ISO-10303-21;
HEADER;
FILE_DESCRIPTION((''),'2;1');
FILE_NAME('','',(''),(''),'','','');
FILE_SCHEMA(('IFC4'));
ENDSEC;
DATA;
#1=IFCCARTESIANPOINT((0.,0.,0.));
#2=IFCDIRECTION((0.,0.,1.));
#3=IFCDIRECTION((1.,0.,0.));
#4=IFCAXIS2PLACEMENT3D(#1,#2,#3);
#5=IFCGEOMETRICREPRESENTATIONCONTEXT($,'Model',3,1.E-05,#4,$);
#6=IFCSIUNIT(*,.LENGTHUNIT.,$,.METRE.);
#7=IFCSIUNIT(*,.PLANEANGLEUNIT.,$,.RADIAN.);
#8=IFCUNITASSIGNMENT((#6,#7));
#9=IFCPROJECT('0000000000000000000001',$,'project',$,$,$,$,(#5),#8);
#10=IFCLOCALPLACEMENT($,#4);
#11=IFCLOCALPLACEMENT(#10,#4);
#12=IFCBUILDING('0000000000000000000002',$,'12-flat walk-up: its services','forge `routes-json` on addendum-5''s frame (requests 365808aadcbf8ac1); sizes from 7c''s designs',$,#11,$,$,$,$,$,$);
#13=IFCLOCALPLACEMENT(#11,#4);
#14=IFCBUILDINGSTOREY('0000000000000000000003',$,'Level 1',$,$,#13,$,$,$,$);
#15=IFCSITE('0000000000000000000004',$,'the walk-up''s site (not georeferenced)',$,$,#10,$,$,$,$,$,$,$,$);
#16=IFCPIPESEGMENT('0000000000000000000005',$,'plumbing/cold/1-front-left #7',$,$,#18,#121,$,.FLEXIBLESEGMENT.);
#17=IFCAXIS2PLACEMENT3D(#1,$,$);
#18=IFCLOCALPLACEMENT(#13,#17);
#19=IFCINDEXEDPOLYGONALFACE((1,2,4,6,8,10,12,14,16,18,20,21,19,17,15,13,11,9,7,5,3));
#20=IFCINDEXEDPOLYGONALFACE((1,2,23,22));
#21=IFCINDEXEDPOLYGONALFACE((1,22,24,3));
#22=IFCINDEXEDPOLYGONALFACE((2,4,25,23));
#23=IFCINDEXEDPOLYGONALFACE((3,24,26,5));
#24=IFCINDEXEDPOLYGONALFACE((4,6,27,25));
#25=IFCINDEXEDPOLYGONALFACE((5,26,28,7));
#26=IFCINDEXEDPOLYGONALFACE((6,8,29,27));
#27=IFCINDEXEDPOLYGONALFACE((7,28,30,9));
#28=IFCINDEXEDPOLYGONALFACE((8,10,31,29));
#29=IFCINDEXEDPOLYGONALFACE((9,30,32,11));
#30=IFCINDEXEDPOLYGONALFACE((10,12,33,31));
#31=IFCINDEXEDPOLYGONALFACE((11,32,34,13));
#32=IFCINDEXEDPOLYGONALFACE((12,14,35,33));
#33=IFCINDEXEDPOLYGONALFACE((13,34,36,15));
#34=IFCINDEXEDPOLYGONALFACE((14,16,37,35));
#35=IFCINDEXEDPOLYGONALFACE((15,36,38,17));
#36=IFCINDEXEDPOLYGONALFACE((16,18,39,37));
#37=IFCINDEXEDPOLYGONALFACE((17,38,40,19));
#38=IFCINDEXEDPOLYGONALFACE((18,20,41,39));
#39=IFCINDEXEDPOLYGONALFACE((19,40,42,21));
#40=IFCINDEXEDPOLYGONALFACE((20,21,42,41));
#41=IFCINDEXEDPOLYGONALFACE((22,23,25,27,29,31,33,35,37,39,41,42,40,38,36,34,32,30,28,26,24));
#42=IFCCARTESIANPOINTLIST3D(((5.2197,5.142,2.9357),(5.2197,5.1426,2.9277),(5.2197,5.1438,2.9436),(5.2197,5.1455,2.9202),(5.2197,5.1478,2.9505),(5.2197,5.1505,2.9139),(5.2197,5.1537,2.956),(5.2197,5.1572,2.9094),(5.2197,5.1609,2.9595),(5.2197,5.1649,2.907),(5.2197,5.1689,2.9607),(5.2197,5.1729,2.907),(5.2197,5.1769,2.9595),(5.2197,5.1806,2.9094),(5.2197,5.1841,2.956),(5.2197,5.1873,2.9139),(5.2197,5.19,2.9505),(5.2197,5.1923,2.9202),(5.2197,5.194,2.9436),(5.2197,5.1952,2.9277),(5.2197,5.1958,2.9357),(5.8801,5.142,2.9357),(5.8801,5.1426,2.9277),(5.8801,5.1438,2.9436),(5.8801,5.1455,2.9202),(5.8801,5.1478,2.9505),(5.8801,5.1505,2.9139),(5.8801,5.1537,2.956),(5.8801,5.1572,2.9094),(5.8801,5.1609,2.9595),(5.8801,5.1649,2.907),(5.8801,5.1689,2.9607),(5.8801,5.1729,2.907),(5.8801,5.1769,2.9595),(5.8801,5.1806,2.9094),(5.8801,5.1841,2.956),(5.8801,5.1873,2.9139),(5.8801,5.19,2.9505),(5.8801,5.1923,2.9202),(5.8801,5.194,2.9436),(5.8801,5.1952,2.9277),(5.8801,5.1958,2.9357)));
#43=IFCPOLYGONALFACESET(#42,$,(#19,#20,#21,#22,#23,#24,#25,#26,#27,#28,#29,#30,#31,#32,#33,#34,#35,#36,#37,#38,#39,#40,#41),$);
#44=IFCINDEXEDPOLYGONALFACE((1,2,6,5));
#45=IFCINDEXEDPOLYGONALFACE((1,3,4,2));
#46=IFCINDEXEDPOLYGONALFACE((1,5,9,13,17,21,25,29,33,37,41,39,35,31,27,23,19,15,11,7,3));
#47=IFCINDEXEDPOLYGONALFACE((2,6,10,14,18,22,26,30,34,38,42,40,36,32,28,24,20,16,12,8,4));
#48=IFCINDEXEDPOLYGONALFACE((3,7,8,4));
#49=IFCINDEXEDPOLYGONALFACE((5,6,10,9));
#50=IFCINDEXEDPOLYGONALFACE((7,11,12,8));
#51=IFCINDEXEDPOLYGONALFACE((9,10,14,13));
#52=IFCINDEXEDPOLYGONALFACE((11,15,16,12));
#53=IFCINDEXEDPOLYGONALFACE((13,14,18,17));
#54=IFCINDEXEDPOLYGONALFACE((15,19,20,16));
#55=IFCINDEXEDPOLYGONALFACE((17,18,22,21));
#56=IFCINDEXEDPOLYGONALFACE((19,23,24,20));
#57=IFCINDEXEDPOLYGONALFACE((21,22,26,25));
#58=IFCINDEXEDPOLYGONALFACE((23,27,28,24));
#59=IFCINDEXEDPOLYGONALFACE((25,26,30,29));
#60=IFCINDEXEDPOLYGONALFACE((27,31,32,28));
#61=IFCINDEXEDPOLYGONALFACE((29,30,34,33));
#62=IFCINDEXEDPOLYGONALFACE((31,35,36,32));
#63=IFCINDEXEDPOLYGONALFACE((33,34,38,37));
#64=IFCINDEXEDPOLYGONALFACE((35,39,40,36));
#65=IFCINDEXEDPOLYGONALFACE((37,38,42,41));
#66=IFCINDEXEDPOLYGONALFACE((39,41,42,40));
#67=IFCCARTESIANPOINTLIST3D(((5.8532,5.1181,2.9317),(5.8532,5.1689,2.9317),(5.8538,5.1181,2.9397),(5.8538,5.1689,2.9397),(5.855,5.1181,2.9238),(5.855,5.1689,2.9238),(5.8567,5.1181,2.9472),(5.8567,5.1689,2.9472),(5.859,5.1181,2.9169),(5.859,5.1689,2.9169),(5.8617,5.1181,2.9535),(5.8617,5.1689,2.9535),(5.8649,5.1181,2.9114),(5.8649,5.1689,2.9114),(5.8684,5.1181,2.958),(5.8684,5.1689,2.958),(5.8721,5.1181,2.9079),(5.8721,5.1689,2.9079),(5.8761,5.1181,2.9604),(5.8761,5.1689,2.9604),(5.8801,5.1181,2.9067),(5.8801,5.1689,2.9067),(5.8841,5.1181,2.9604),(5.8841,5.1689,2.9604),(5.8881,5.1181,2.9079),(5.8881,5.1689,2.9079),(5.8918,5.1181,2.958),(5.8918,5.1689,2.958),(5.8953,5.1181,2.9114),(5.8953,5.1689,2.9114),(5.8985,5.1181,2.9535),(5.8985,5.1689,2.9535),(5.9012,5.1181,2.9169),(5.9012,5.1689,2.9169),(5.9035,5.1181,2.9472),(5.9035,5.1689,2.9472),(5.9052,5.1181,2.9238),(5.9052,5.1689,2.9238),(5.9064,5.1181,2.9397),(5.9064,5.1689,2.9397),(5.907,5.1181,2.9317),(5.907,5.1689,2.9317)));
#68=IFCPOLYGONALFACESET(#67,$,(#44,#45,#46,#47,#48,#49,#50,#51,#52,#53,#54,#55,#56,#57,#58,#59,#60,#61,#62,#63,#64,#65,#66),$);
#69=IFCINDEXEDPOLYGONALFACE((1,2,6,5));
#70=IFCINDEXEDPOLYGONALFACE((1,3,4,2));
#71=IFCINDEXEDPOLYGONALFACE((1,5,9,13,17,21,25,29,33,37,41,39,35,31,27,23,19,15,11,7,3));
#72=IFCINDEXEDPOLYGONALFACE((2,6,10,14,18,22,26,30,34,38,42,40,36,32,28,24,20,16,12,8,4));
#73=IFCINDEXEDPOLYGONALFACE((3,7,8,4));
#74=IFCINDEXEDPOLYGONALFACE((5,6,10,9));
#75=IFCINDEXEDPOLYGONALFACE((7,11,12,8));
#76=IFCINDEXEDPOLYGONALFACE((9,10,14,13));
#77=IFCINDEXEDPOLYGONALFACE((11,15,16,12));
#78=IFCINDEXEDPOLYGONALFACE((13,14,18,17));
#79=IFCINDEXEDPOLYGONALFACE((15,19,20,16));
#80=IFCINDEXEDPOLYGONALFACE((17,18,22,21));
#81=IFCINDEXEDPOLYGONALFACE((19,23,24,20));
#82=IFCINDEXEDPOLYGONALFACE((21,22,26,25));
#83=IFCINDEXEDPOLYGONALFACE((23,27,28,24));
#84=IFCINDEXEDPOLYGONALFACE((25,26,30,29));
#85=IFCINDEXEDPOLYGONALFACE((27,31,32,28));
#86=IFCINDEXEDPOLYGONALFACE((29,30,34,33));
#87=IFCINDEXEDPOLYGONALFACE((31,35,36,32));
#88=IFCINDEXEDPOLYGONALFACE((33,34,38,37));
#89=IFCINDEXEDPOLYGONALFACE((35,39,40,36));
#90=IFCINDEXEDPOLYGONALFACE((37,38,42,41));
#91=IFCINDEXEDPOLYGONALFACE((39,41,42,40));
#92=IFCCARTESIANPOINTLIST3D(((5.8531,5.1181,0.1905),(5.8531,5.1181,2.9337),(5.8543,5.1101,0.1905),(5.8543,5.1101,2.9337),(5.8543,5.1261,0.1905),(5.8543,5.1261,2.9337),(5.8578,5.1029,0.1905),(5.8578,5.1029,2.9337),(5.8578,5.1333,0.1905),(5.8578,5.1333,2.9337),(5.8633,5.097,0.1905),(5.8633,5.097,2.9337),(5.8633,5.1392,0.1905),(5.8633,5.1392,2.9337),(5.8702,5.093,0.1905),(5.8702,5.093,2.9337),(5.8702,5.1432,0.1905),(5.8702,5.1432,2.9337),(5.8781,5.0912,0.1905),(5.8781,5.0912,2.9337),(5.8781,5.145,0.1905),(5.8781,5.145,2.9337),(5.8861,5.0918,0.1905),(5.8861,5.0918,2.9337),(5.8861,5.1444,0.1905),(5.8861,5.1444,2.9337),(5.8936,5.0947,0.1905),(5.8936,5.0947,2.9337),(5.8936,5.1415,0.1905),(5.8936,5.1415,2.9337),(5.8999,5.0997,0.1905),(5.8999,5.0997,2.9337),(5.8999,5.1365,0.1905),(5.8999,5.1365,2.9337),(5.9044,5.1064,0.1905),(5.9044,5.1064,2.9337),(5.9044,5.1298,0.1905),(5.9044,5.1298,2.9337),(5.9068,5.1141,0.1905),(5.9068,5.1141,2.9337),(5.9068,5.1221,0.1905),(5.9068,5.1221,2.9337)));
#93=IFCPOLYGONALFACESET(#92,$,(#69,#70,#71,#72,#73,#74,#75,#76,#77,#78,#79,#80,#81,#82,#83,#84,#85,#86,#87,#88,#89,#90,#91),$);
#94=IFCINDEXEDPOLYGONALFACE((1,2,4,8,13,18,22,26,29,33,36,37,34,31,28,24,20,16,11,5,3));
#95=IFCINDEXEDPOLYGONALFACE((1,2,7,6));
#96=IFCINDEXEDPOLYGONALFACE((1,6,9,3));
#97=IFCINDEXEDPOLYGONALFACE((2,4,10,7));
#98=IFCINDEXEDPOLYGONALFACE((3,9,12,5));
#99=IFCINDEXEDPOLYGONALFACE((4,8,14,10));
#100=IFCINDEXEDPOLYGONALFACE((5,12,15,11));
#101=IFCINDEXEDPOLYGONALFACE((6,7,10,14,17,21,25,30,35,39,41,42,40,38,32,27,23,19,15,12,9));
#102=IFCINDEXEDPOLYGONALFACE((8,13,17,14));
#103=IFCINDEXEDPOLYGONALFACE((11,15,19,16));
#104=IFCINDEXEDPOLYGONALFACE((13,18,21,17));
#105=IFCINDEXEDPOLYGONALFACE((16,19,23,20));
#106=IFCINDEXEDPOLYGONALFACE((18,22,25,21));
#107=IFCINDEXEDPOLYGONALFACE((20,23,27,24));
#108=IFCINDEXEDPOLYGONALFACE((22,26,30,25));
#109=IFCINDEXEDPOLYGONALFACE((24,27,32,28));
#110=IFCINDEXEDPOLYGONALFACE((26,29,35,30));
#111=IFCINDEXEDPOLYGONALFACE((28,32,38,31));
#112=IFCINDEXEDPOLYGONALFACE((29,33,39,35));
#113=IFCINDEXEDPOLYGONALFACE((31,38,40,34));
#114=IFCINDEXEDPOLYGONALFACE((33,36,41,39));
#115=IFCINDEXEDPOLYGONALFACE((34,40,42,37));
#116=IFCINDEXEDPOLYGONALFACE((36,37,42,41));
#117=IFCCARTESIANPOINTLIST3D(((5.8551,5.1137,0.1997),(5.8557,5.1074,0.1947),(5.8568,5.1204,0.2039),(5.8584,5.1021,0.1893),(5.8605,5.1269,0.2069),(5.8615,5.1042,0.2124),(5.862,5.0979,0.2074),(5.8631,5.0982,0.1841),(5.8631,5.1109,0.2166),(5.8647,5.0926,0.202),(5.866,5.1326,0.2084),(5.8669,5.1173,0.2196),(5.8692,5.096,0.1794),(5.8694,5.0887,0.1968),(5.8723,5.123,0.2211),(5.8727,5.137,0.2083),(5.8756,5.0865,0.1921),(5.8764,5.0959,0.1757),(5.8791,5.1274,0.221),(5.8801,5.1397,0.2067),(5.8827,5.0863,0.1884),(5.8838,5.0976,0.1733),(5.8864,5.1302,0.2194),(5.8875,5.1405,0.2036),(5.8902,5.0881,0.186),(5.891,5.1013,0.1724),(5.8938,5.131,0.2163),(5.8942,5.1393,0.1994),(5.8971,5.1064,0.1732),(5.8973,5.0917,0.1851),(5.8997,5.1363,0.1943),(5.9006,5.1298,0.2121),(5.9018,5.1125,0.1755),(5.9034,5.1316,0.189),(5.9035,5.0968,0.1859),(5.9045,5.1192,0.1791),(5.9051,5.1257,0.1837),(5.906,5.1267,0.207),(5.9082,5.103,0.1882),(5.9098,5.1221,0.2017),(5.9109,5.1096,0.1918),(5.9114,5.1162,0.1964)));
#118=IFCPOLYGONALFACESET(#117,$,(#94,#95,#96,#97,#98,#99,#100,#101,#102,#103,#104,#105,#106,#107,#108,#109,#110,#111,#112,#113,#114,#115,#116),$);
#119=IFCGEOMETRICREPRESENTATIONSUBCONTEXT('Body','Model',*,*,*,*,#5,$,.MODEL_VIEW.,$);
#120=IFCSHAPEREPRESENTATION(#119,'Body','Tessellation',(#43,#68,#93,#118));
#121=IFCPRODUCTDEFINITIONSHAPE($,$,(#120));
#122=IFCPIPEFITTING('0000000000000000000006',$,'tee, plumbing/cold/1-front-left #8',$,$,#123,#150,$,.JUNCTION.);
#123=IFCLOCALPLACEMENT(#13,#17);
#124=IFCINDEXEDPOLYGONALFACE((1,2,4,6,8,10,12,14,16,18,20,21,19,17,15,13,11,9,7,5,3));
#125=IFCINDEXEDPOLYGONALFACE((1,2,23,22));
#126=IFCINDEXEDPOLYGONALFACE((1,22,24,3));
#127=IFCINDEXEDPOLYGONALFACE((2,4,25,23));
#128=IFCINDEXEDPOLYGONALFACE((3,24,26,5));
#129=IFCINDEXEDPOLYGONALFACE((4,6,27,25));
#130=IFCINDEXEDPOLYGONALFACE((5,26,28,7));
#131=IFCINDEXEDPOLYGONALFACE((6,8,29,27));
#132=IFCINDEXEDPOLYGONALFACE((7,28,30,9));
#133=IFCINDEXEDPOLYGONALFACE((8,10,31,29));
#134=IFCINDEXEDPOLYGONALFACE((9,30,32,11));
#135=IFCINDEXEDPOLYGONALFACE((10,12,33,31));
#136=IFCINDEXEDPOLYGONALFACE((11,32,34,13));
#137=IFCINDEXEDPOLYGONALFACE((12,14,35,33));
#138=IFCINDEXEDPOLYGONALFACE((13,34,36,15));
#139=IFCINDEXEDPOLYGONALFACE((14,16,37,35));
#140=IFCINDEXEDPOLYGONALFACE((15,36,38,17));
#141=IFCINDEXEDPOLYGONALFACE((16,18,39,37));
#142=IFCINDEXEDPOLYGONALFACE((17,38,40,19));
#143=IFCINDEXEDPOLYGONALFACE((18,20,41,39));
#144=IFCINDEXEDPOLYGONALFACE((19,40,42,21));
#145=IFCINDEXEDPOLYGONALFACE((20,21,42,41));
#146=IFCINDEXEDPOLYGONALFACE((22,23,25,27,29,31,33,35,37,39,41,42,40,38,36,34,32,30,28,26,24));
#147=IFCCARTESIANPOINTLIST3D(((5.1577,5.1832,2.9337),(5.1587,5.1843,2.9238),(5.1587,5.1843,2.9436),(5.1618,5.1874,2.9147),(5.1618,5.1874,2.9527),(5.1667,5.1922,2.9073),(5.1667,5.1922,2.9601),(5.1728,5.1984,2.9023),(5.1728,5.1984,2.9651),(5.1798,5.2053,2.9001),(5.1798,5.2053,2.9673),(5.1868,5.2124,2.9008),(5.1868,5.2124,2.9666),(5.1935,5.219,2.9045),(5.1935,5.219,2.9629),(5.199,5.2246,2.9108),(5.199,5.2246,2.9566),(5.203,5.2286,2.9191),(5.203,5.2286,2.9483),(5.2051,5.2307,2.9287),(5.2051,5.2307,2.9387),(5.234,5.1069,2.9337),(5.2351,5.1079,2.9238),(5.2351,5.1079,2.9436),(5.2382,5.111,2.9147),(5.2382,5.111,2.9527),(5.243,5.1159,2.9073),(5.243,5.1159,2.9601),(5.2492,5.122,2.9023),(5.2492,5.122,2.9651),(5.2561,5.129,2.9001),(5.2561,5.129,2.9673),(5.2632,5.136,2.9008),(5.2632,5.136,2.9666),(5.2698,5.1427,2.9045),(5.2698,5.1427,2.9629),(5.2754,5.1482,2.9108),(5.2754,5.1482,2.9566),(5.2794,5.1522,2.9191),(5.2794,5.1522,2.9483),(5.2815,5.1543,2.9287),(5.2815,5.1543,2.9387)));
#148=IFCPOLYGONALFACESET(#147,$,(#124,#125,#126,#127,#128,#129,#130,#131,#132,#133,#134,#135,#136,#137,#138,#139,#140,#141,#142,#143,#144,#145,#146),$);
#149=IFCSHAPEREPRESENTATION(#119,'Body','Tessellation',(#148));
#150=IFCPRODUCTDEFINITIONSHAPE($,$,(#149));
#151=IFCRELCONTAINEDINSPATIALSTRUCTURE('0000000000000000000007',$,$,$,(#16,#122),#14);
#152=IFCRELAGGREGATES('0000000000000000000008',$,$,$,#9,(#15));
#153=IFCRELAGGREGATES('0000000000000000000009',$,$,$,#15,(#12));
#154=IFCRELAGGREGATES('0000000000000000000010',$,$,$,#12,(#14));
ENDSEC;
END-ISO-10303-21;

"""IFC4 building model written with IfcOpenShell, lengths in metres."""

from ifc_helpers import new_model, entity, si_unit, frame, origin_with_axes, place, context, subcontext, project, spatial, element, save


model = new_model("IFC4")

# Units and contexts
model_context = context("Model", 3, precision=1e-05, world=origin_with_axes())
body_context = subcontext(model_context, "Body", "Model", "MODEL_VIEW")
ifc_project = project(units=[si_unit("LENGTHUNIT", "METRE"), si_unit("PLANEANGLEUNIT", "RADIAN")], contexts=[model_context])

# Site, building, storey
site_placement = place(None, origin_with_axes())
site = spatial("IfcSite", under=ifc_project, at=site_placement, Name="the walk-up's site (not georeferenced)")
building_placement = place(site_placement, origin_with_axes())
building = spatial("IfcBuilding", under=site, at=building_placement, Name="12-flat walk-up: its services", Description="forge `routes-json` on addendum-5's frame (requests 365808aadcbf8ac1); sizes from 7c's designs")
storey_placement = place(building_placement, origin_with_axes())
storey = spatial("IfcBuildingStorey", under=building, at=storey_placement, Name="Level 1")

# Pipe segment
pipe_segment_1_placement = place(storey_placement, frame((5.2197, 5.1689, 2.9337), z_axis=(0.0, 0.0, 1.0), x_axis=(1.0, 0.0, 0.0)))
element("IfcPipeSegment", 1, at=pipe_segment_1_placement, inside=storey, Name="plumbing/cold/1-front-left #7", PredefinedType="FLEXIBLESEGMENT", context=body_context, shape_type="AdvancedSweptSolid", body=[
    entity("IfcSweptDiskSolid", entity("IfcPolyline", [entity("IfcCartesianPoint", [0.0, 0.0, 0.0]), entity("IfcCartesianPoint", [0.6604, 0.0, 0.0])]), 0.027),
    entity("IfcSweptDiskSolid", entity("IfcPolyline", [entity("IfcCartesianPoint", [0.6604, 0.0, 0.0]), entity("IfcCartesianPoint", [0.6604, -0.0508, 0.0])]), 0.027),
    entity("IfcSweptDiskSolid", entity("IfcPolyline", [entity("IfcCartesianPoint", [0.6604, -0.0508, 0.0]), entity("IfcCartesianPoint", [0.6604, -0.0508, -2.7432])]), 0.027),
    entity("IfcSweptDiskSolid", entity("IfcPolyline", [entity("IfcCartesianPoint", [0.6604, -0.0508, -2.7432]), entity("IfcCartesianPoint", [0.6668, -0.0603, -2.7305])]), 0.027),
])

# Pipe fitting
pipe_fitting_1_placement = place(storey_placement, frame((5.1815, 5.2071, 2.9337), z_axis=(0.0, 0.0, 1.0), x_axis=(1.0, 0.0, 0.0)))
element("IfcPipeFitting", 2, at=pipe_fitting_1_placement, inside=storey, Name="tee, plumbing/cold/1-front-left #8", PredefinedType="JUNCTION", context=body_context, shape_type="AdvancedSweptSolid", body=[
    entity("IfcSweptDiskSolid", entity("IfcPolyline", [entity("IfcCartesianPoint", [0.0, 0.0, 0.0]), entity("IfcCartesianPoint", [0.0763, -0.0763, 0.0])]), 0.0337),
])

save(model, "model.ifc")
